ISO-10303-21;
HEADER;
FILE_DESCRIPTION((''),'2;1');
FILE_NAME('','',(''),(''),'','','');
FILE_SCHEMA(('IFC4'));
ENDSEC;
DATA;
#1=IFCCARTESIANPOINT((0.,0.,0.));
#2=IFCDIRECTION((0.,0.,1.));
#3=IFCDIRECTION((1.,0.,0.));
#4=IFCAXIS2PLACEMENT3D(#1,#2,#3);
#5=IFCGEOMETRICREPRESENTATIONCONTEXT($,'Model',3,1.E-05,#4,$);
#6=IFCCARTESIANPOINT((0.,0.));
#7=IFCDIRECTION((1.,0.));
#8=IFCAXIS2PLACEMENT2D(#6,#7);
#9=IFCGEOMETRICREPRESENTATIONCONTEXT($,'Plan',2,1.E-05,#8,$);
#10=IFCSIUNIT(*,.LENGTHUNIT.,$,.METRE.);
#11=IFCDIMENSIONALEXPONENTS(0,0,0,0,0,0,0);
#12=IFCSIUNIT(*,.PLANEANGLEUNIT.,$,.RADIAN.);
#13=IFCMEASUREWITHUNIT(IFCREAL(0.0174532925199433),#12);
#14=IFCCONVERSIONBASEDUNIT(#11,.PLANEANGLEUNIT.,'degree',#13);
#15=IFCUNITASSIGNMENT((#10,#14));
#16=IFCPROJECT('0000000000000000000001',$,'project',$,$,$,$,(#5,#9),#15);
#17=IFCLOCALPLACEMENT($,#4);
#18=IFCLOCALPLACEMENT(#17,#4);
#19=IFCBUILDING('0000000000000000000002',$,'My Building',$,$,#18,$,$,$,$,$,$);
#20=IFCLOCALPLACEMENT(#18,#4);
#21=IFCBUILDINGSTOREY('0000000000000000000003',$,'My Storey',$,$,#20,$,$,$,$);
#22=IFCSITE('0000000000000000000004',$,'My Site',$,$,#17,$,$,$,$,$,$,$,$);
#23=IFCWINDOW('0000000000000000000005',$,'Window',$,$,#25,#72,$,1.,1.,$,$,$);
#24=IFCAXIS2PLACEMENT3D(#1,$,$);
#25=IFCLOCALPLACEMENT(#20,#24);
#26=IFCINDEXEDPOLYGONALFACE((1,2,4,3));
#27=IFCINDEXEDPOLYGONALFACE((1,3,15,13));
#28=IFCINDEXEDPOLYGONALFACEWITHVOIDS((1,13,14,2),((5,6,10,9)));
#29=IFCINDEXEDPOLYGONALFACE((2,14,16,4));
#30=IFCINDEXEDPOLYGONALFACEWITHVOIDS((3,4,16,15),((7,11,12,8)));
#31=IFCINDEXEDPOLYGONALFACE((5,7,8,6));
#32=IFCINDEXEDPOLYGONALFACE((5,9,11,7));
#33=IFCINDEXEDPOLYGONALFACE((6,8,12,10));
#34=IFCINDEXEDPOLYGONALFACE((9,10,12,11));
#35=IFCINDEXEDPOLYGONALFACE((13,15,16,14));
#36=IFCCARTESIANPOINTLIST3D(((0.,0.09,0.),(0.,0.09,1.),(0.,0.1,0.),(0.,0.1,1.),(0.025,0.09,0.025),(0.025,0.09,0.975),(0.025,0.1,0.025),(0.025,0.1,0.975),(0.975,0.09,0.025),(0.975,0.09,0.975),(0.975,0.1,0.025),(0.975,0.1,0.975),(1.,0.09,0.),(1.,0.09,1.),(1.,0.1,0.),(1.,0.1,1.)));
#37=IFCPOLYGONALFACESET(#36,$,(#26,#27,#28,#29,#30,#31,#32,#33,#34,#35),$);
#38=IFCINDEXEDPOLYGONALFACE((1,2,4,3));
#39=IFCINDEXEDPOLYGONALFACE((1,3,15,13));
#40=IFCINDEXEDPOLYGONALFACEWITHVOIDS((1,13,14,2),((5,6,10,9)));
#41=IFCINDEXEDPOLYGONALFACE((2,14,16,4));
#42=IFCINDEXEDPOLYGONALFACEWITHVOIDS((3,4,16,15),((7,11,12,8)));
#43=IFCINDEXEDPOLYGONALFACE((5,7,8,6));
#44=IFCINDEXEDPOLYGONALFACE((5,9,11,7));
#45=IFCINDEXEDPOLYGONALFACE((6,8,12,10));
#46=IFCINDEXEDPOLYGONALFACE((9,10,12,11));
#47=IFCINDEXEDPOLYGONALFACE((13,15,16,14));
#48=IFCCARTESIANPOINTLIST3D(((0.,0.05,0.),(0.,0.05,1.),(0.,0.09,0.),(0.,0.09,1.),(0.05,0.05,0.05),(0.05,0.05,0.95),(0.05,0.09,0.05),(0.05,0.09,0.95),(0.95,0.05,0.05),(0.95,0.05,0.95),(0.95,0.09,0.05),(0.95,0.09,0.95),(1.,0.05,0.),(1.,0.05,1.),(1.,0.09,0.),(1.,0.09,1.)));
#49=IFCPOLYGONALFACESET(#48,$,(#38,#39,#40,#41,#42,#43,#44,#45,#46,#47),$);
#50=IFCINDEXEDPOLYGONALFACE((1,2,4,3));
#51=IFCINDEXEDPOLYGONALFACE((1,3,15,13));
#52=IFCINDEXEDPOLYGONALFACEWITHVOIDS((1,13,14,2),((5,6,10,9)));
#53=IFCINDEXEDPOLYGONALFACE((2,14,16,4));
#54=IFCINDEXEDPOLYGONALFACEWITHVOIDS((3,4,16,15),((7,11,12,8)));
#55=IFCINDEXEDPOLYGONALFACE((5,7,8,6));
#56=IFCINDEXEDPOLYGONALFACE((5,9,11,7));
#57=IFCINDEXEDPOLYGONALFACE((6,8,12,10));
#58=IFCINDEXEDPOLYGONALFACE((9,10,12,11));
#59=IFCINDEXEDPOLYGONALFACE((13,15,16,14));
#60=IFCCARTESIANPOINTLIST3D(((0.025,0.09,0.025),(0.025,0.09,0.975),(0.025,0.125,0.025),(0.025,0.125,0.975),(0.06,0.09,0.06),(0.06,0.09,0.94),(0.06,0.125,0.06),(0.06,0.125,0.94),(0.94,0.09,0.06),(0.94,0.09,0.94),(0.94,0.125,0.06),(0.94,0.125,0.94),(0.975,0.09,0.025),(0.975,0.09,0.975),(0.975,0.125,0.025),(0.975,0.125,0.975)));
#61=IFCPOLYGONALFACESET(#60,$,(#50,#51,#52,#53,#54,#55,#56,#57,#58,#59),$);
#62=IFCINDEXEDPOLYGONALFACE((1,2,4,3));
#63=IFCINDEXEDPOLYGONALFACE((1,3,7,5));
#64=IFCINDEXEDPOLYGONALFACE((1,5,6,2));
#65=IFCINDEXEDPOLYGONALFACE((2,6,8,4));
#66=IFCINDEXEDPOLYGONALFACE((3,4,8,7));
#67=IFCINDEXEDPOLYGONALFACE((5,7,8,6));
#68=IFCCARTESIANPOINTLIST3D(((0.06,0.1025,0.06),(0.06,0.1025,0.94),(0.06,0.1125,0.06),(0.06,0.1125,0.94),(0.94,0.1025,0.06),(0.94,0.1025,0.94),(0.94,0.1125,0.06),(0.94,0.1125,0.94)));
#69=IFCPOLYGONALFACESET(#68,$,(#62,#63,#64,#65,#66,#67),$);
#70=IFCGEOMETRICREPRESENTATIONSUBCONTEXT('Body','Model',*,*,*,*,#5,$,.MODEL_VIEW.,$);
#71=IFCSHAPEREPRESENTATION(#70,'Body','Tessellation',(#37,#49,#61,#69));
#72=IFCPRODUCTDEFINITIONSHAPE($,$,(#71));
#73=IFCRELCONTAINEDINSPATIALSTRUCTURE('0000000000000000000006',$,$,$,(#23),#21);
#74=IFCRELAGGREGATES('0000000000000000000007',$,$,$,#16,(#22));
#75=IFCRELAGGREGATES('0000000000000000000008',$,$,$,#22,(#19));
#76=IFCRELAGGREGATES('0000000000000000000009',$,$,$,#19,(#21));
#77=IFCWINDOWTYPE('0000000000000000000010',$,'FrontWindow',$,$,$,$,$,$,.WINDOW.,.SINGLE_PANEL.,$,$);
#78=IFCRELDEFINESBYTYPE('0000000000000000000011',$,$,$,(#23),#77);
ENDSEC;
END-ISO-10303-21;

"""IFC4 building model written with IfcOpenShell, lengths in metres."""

from ifc_helpers import new_model, entity, si_unit, converted_unit, frame, origin_with_axes, origin_2d_with_axis, place, context, subcontext, project, spatial, line, indexed_curve, outline, extrude, shape, source, transform, mapped, type_object, type_shapes, element, save


model = new_model("IFC4")

# Units and contexts
model_context = context("Model", 3, precision=1e-05, world=origin_with_axes())
plan_context = context("Plan", 2, precision=1e-05, world=origin_2d_with_axis())
body_context_1 = subcontext(model_context, "Body", "Model", "MODEL_VIEW")
body_context_2 = subcontext(plan_context, "Body", "Plan", "PLAN_VIEW")
ifc_project = project(units=[si_unit("LENGTHUNIT", "METRE"), converted_unit("PLANEANGLEUNIT", "degree", entity("IfcReal", 0.0174532925199433), si_unit("PLANEANGLEUNIT", "RADIAN"), dimensions=[0, 0, 0, 0, 0, 0, 0])], contexts=[model_context, plan_context])

# Site, building, storey
site_placement = place(None, origin_with_axes())
site = spatial("IfcSite", under=ifc_project, at=site_placement, Name="My Site")
building_placement = place(site_placement, origin_with_axes())
building = spatial("IfcBuilding", under=site, at=building_placement, Name="My Building")
storey_placement = place(building_placement, origin_with_axes())
storey = spatial("IfcBuildingStorey", under=building, at=storey_placement, Name="My Storey")

# Shared definitions
window_type = type_object("IfcWindowType", Name="FrontWindow", PartitioningType="SINGLE_PANEL", PredefinedType="WINDOW")
shared_shape_1 = source(origin_with_axes(), body_context_1, "Body", "SweptSolid", [
    extrude(outline(indexed_curve([(0.0, 0.0), (1.0, 0.0), (1.0, 1.0), (0.0, 1.0)], segments=[line(1, 2, 3, 4, 1)]), holes=[indexed_curve([(0.025, 0.025), (0.975, 0.025), (0.975, 0.975), (0.025, 0.975)], segments=[line(1, 2, 3, 4, 1)])]), frame((0.0, 0.09, 0.0), z_axis=(0.0, -1.0, 0.0), x_axis=(1.0, 0.0, 0.0)), (0.0, 0.0, -1.0), 0.01),
    extrude(outline(indexed_curve([(0.0, 0.0), (1.0, 0.0), (1.0, 1.0), (0.0, 1.0)], segments=[line(1, 2, 3, 4, 1)]), holes=[indexed_curve([(0.05, 0.05), (0.95, 0.05), (0.95, 0.95), (0.05, 0.95)], segments=[line(1, 2, 3, 4, 1)])]), frame((0.0, 0.05, 0.0), z_axis=(0.0, -1.0, 0.0), x_axis=(1.0, 0.0, 0.0)), (0.0, 0.0, -1.0), 0.04),
    extrude(outline(indexed_curve([(0.0, 0.0), (0.95, 0.0), (0.95, 0.95), (0.0, 0.95)], segments=[line(1, 2, 3, 4, 1)]), holes=[indexed_curve([(0.035, 0.035), (0.915, 0.035), (0.915, 0.915), (0.035, 0.915)], segments=[line(1, 2, 3, 4, 1)])]), frame((0.025, 0.09, 0.025), z_axis=(0.0, -1.0, 0.0), x_axis=(1.0, 0.0, 0.0)), (0.0, 0.0, -1.0), 0.035),
    extrude(outline(indexed_curve([(0.035, 0.035), (0.915, 0.035), (0.915, 0.915), (0.035, 0.915)], segments=[line(1, 2, 3, 4, 1)])), frame((0.025, 0.1025, 0.025), z_axis=(0.0, -1.0, 0.0), x_axis=(1.0, 0.0, 0.0)), (0.0, 0.0, -1.0), 0.01),
])
shared_shape_2 = source(origin_with_axes(), body_context_2, "Body", "Curve2D", [
    entity("IfcIndexedPolyCurve", entity("IfcCartesianPointList2D", [[0.05, 0.05], [0.95, 0.05]])),
    entity("IfcIndexedPolyCurve", entity("IfcCartesianPointList2D", [[0.0, 0.1], [0.025, 0.1], [0.025, 0.09], [0.05, 0.09], [0.05, 0.05], [0.0, 0.05]]), [entity("IfcLineIndex", [1, 2, 3, 4, 5, 6, 1])]),
    entity("IfcIndexedPolyCurve", entity("IfcCartesianPointList2D", [[1.0, 0.1], [0.975, 0.1], [0.975, 0.09], [0.95, 0.09], [0.95, 0.05], [1.0, 0.05]]), [entity("IfcLineIndex", [1, 2, 3, 4, 5, 6, 1])]),
    entity("IfcIndexedPolyCurve", entity("IfcCartesianPointList2D", [[0.025, 0.09], [0.06, 0.09], [0.06, 0.125], [0.025, 0.125]]), [entity("IfcLineIndex", [1, 2, 3, 4, 1])]),
    entity("IfcIndexedPolyCurve", entity("IfcCartesianPointList2D", [[0.975, 0.09], [0.94, 0.09], [0.94, 0.125], [0.975, 0.125]]), [entity("IfcLineIndex", [1, 2, 3, 4, 1])]),
    entity("IfcIndexedPolyCurve", entity("IfcCartesianPointList2D", [[0.06, 0.09], [0.94, 0.09]])),
    entity("IfcIndexedPolyCurve", entity("IfcCartesianPointList2D", [[0.06, 0.125], [0.94, 0.125]])),
    entity("IfcIndexedPolyCurve", entity("IfcCartesianPointList2D", [[0.06, 0.1075], [0.94, 0.1075]])),
])
type_shapes(window_type, [shared_shape_1, shared_shape_2])

# Window
window_1_placement = place(storey_placement, origin_with_axes())
element("IfcWindow", 1, at=window_1_placement, inside=storey, type_object=window_type, Name="Window", OverallHeight=1.0, OverallWidth=1.0, shapes=[
    shape(body_context_1, "Body", "MappedRepresentation", [mapped(shared_shape_1, transform((0.0, 0.0, 0.0), x_axis=(1.0, 0.0, 0.0), y_axis=(0.0, 1.0, 0.0), z_axis=(0.0, 0.0, 1.0), scale=1.0))]),
    shape(body_context_2, "Body", "MappedRepresentation", [mapped(shared_shape_2, transform((0.0, 0.0, 0.0), x_axis=(1.0, 0.0, 0.0), y_axis=(0.0, 1.0, 0.0), z_axis=(0.0, 0.0, 1.0), scale=1.0))]),
])

save(model, "model.ifc")
